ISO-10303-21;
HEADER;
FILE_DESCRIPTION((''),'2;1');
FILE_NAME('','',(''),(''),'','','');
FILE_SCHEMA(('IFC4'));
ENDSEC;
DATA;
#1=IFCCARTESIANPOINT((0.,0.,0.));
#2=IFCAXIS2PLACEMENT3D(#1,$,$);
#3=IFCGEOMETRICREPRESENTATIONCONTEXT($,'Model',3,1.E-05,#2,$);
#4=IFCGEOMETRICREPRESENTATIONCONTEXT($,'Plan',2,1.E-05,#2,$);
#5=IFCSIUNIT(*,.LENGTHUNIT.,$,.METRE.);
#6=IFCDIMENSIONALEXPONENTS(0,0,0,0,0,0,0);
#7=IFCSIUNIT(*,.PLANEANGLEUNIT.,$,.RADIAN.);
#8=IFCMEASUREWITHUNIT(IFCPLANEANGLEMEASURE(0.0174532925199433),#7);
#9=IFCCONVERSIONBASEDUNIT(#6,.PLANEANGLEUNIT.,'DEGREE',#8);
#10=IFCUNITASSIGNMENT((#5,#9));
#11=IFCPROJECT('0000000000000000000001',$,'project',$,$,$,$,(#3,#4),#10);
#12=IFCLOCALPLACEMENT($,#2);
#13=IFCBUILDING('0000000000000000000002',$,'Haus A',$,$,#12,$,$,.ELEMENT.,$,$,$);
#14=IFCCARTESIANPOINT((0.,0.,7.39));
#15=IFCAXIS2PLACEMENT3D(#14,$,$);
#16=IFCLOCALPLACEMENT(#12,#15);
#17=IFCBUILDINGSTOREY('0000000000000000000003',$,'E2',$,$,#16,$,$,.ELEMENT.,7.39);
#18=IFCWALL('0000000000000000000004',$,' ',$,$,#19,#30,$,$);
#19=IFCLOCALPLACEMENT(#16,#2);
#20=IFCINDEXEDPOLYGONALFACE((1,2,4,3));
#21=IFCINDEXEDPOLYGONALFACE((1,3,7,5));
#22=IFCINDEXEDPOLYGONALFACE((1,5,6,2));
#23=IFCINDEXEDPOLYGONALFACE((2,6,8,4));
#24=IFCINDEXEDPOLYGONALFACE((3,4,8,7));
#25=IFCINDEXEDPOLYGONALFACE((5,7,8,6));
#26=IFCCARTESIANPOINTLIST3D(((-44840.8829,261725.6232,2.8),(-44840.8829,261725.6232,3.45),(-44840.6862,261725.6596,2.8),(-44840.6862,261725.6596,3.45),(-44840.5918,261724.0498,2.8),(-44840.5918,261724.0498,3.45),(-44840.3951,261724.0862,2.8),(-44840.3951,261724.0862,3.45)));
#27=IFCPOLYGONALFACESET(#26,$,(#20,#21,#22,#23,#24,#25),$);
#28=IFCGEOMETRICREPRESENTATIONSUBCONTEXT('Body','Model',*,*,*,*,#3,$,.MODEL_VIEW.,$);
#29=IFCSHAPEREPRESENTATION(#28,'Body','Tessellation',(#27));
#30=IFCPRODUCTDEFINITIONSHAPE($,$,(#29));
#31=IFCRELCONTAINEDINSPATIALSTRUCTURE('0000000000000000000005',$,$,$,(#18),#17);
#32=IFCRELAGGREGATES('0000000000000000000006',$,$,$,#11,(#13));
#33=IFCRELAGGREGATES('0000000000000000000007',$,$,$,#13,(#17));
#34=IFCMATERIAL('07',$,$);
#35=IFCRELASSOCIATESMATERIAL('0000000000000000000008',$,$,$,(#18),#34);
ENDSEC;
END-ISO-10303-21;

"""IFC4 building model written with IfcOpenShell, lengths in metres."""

from ifc_helpers import new_model, entity, si_unit, converted_unit, frame, frame_2d, origin, origin_with_axes, place, context, subcontext, project, spatial, rectangle, extrude, material, element, save


model = new_model("IFC4")

# Units and contexts
model_context = context("Model", 3, precision=1e-05, world=origin())
plan_context = context("Plan", 2, precision=1e-05, world=origin())
body_context = subcontext(model_context, "Body", "Model", "MODEL_VIEW")
ifc_project = project(units=[si_unit("LENGTHUNIT", "METRE"), converted_unit("PLANEANGLEUNIT", "DEGREE", entity("IfcPlaneAngleMeasure", 0.0174532925199433), si_unit("PLANEANGLEUNIT", "RADIAN"), dimensions=[0, 0, 0, 0, 0, 0, 0])], contexts=[model_context, plan_context])

# Building, storey
building_placement = place(None, origin())
building = spatial("IfcBuilding", under=ifc_project, at=building_placement, Name="Haus A", CompositionType="ELEMENT")
storey_placement = place(building_placement, frame((0.0, 0.0, 7.39)))
storey = spatial("IfcBuildingStorey", under=building, at=storey_placement, Name="E2", CompositionType="ELEMENT", Elevation=7.39)

# Wall
ifc_material_1 = material(Name="07")
wall_1_placement = place(storey_placement, frame((-44840.3951, 261724.0862, 2.8), z_axis=(0.0, 0.0, 1.0), x_axis=(-0.18192, 0.983313, 0.0)))
element("IfcWall", 1, at=wall_1_placement, inside=storey, material=ifc_material_1, Name=" ", context=body_context, shape_type="SweptSolid", body=[
    extrude(rectangle(XDim=1.6001, YDim=0.2, at=frame_2d((0.8001, 0.1), x_axis=(1.0, 0.0))), origin_with_axes(), (0.0, 0.0, 1.0), 0.65),
])

save(model, "model.ifc")
